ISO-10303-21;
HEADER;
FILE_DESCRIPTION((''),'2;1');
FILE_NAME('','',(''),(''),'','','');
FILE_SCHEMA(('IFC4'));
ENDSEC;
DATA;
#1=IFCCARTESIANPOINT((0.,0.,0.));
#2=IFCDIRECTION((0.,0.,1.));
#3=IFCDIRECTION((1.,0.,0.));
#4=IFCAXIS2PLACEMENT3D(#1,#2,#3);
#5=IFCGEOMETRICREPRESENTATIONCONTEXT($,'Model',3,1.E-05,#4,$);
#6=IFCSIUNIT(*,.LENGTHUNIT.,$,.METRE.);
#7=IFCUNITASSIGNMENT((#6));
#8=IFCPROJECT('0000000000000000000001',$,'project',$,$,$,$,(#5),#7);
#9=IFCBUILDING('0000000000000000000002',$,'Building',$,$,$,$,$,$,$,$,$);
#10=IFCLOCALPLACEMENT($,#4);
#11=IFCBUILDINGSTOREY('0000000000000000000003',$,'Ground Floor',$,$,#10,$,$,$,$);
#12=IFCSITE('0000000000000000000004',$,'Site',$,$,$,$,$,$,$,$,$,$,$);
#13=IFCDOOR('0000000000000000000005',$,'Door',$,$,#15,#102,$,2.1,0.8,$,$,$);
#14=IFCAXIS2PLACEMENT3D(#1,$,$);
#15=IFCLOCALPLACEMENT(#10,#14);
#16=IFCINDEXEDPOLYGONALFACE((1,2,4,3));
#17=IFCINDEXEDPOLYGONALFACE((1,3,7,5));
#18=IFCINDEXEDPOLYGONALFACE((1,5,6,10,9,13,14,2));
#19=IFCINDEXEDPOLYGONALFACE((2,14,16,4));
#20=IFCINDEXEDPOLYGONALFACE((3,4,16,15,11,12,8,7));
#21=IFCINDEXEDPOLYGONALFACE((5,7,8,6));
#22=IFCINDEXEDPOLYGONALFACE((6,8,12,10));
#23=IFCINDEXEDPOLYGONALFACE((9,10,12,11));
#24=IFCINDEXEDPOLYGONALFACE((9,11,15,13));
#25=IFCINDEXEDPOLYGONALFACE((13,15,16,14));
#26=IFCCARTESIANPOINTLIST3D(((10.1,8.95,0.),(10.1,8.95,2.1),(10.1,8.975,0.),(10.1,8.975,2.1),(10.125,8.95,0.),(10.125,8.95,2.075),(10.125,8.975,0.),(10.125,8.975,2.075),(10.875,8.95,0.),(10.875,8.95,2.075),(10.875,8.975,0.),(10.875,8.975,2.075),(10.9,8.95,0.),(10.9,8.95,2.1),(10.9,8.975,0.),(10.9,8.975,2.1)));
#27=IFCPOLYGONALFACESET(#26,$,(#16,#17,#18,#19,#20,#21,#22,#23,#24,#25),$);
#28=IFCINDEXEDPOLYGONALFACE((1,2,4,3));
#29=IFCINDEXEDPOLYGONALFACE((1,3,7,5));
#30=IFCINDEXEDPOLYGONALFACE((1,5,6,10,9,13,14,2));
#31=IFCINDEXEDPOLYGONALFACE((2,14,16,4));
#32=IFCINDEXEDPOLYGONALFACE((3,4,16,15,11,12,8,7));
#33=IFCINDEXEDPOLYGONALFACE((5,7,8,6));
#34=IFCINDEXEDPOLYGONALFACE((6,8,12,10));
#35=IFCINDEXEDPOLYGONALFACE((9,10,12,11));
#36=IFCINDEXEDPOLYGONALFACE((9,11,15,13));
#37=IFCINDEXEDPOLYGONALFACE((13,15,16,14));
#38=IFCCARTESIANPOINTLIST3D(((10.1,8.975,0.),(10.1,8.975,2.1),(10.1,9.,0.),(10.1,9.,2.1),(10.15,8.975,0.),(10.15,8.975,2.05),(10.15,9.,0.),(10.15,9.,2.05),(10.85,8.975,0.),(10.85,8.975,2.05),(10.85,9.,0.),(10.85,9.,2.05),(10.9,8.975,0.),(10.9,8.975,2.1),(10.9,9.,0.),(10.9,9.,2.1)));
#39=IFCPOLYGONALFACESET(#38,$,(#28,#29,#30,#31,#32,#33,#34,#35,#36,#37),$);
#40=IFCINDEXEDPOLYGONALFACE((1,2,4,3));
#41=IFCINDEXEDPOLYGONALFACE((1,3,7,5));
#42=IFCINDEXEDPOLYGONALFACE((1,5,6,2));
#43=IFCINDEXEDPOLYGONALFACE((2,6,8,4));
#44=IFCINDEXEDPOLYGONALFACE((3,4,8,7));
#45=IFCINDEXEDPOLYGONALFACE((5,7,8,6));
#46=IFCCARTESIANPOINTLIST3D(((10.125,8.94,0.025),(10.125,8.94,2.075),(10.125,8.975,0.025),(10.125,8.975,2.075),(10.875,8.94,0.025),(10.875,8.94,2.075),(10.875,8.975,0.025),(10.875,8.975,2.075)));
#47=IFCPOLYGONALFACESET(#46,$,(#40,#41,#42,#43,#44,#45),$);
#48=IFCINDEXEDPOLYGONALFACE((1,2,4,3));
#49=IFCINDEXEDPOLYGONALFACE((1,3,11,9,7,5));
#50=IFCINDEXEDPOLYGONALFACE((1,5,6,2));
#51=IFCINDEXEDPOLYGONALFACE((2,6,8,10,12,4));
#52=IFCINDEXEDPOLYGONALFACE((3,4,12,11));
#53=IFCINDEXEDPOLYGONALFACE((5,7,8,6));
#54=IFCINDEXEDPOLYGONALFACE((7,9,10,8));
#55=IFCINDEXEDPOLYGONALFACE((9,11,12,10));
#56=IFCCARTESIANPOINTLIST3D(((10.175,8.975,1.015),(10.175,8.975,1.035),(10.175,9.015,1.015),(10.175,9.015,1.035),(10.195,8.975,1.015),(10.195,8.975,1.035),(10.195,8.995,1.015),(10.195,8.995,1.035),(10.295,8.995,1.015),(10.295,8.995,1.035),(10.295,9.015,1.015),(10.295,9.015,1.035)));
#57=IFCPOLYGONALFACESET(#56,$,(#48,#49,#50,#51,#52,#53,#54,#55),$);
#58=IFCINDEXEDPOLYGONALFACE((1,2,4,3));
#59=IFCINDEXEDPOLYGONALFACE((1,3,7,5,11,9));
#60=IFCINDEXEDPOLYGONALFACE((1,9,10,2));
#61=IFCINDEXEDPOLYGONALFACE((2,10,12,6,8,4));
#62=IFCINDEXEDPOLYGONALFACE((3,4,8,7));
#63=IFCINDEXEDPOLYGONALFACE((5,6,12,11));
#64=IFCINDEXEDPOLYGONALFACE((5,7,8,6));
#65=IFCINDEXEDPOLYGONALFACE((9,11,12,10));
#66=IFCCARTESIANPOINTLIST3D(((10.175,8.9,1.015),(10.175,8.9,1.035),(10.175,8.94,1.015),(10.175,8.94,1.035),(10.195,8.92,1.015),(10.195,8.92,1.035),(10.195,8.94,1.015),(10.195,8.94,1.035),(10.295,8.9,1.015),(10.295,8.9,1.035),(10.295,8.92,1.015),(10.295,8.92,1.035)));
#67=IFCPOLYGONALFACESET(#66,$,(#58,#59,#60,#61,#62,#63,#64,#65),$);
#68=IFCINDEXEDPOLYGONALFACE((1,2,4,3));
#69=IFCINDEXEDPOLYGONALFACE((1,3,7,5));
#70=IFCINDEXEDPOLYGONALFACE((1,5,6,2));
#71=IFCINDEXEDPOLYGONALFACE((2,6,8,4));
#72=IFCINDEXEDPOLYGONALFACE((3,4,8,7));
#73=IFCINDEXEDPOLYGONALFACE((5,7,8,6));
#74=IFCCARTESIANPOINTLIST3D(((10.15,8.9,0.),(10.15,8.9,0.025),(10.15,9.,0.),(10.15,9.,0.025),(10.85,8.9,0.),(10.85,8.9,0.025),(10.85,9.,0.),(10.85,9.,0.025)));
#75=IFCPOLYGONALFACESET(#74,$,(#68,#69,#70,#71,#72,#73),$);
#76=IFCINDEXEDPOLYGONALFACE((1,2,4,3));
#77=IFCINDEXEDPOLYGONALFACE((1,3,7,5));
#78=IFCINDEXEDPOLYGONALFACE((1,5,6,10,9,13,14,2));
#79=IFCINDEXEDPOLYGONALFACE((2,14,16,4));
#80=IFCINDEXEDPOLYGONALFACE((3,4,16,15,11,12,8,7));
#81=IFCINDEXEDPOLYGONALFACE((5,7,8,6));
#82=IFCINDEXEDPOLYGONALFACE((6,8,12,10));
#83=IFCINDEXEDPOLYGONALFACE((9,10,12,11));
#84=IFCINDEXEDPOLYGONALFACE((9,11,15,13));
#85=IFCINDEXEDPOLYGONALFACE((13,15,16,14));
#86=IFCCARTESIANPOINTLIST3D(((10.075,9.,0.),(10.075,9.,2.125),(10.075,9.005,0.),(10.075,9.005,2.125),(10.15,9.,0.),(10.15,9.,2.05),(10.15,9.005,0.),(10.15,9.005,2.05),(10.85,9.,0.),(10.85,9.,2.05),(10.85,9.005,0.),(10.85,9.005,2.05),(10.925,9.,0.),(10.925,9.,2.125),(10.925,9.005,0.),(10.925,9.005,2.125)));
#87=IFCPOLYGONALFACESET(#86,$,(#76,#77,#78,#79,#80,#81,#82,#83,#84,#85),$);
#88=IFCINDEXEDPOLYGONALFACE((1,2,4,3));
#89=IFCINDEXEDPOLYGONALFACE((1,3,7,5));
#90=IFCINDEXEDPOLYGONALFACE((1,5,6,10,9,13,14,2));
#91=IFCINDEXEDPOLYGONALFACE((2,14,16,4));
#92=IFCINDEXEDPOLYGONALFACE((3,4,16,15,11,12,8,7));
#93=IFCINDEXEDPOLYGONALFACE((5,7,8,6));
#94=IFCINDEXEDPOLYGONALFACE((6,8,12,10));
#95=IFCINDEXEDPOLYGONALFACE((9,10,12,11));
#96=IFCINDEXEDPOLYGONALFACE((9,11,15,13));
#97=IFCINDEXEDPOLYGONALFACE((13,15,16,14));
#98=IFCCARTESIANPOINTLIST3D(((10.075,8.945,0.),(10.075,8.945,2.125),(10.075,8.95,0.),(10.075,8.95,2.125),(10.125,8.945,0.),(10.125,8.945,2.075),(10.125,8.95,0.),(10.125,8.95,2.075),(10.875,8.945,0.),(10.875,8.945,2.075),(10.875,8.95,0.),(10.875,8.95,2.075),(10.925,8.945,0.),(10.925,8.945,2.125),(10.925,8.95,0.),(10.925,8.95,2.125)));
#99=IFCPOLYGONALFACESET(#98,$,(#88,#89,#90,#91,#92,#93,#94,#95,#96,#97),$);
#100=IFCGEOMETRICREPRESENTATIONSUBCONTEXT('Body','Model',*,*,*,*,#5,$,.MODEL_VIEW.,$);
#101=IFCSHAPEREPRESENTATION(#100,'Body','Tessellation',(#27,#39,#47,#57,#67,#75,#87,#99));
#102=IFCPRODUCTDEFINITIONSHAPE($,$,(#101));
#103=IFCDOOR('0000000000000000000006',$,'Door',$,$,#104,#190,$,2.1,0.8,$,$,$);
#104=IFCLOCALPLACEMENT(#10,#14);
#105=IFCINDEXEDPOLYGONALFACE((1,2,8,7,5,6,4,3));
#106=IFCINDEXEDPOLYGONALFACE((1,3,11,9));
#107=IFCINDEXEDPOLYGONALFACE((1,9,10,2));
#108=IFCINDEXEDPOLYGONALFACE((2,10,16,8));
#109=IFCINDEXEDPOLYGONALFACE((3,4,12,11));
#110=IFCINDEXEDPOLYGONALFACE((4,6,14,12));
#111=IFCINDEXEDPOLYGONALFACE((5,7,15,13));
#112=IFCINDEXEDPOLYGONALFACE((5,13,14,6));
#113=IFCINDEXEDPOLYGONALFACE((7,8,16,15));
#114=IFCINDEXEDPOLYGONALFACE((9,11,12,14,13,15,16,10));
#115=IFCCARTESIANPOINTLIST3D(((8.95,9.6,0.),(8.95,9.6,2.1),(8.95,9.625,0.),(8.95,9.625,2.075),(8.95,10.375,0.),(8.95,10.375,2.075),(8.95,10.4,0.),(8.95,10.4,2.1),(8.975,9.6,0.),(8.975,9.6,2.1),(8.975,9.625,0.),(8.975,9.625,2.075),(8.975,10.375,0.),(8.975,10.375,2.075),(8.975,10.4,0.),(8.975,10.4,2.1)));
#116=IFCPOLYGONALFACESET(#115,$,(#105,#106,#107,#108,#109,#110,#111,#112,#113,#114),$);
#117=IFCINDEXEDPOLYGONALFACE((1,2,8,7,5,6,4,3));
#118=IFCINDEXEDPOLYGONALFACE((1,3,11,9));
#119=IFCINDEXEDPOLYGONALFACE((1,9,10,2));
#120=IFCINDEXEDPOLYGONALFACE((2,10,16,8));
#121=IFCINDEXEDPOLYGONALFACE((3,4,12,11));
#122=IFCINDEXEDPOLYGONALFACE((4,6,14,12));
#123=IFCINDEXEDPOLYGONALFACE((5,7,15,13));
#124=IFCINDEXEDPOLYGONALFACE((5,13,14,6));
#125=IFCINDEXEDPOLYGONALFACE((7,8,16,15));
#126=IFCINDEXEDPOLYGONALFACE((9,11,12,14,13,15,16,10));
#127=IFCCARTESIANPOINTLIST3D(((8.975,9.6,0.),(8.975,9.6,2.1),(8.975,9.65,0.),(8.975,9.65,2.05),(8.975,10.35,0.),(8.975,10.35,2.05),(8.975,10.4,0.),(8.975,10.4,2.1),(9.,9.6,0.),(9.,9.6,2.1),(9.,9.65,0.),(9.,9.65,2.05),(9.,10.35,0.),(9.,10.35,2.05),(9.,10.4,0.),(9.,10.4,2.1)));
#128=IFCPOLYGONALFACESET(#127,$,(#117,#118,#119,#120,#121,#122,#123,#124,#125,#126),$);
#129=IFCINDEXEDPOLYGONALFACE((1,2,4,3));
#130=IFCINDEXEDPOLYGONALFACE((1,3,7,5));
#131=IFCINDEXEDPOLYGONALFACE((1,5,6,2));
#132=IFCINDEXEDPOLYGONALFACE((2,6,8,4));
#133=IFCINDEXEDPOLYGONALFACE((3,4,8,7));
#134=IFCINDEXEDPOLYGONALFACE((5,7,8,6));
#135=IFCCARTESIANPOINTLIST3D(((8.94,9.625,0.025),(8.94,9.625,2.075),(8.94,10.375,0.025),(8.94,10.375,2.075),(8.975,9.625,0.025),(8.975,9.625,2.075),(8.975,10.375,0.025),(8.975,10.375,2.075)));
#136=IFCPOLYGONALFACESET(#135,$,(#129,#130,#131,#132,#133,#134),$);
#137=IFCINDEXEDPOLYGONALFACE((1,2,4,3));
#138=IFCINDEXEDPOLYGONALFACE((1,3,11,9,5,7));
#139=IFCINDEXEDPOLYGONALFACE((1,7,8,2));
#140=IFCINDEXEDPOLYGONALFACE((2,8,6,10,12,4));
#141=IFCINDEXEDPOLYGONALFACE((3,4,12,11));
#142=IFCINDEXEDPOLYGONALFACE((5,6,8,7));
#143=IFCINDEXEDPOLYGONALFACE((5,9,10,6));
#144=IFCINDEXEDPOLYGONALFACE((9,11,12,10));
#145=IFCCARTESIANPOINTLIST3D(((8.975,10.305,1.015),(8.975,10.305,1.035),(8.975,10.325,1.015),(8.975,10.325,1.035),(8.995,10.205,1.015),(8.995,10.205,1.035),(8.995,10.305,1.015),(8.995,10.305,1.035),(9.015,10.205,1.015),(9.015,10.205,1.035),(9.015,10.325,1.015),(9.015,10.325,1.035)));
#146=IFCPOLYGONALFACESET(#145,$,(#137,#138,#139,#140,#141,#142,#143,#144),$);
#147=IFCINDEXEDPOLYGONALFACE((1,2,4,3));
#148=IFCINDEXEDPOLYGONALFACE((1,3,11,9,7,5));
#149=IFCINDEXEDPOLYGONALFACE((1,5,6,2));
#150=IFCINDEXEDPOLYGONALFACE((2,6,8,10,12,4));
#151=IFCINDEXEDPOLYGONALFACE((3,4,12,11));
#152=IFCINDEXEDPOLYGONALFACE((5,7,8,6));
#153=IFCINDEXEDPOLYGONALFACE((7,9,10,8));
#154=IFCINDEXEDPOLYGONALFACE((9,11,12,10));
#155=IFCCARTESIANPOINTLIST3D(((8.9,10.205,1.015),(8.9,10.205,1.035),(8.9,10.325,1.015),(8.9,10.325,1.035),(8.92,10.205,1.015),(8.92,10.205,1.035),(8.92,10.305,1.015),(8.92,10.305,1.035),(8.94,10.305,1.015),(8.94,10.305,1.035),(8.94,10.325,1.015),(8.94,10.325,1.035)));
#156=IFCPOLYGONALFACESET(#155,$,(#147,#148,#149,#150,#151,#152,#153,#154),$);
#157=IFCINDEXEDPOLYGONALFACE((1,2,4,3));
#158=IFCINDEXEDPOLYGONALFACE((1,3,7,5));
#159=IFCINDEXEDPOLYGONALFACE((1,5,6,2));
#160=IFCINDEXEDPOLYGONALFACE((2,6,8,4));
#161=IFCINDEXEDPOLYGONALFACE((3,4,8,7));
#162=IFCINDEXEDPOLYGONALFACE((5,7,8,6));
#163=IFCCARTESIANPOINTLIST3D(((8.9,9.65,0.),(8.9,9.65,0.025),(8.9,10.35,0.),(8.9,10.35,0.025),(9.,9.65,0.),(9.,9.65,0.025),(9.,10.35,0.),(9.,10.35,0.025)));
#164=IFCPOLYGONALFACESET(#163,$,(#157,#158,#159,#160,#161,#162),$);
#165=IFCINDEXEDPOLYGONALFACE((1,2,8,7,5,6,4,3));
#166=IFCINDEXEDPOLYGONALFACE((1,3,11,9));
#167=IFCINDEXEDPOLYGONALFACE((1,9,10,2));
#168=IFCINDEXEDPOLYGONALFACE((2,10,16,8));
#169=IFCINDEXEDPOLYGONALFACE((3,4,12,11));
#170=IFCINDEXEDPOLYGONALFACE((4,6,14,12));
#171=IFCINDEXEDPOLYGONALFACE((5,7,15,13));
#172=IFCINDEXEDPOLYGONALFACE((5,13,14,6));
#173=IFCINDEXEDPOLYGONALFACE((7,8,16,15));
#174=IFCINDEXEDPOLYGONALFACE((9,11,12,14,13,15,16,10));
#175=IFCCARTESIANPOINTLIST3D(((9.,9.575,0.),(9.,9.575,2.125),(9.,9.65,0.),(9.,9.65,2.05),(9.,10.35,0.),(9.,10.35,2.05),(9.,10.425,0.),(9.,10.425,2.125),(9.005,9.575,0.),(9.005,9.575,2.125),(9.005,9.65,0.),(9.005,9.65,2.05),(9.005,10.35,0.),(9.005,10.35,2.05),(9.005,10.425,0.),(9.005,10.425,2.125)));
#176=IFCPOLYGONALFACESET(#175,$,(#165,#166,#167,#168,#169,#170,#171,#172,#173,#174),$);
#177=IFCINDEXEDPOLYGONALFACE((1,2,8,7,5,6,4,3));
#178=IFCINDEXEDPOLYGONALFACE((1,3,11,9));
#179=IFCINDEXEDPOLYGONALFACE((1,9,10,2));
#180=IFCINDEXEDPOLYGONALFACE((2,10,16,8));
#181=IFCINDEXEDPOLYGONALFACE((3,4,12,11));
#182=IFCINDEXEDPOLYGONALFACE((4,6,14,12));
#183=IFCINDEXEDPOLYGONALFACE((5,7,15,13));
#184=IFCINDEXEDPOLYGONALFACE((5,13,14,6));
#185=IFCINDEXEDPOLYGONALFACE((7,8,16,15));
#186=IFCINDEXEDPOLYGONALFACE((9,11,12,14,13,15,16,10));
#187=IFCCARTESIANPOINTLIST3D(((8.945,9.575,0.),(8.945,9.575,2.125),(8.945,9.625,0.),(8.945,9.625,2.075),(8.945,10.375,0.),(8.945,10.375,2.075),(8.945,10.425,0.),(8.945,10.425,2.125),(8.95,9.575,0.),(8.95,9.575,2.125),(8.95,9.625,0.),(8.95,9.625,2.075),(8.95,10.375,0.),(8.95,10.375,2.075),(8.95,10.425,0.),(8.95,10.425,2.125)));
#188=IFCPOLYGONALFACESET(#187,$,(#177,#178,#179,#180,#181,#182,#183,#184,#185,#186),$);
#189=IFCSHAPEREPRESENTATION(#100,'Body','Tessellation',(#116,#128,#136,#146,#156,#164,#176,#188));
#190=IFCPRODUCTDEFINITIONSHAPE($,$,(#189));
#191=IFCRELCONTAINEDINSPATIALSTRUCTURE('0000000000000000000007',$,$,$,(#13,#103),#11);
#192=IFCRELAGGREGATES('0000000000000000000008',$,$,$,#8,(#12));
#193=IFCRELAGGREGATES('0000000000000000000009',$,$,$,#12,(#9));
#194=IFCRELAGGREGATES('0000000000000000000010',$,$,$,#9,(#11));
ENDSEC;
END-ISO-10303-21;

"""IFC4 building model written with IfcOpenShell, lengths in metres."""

from ifc_helpers import new_model, si_unit, frame, origin_with_axes, place, context, subcontext, project, spatial, line, indexed_curve, outline, extrude, element, save


model = new_model("IFC4")

# Units and contexts
model_context = context("Model", 3, precision=1e-05, world=origin_with_axes())
body_context = subcontext(model_context, "Body", "Model", "MODEL_VIEW")
ifc_project = project(units=[si_unit("LENGTHUNIT", "METRE")], contexts=[model_context])

# Site, building, storey
site = spatial("IfcSite", under=ifc_project, Name="Site")
building = spatial("IfcBuilding", under=site, Name="Building")
storey_placement = place(None, origin_with_axes())
storey = spatial("IfcBuildingStorey", under=building, at=storey_placement, Name="Ground Floor")

# Doors
door_1_placement = place(storey_placement, frame((10.9, 9.0, 0.0), z_axis=(0.0, 0.0, 1.0), x_axis=(-1.0, 0.0, 0.0)))
element("IfcDoor", 1, at=door_1_placement, inside=storey, Name="Door", OverallHeight=2.1, OverallWidth=0.8, context=body_context, shape_type="SweptSolid", body=[
    extrude(outline(indexed_curve([(0.0, 0.0), (0.0, 2.1), (0.8, 2.1), (0.8, 0.0), (0.775, 0.0), (0.775, 2.075), (0.025, 2.075), (0.025, 0.0)], segments=[line(1, 2, 3, 4, 5, 6, 7, 8, 1)])), frame((0.0, 0.025, 0.0), z_axis=(0.0, -1.0, 0.0), x_axis=(1.0, 0.0, 0.0)), (0.0, 0.0, -1.0), 0.025),
    extrude(outline(indexed_curve([(0.0, 0.0), (0.0, 2.1), (0.8, 2.1), (0.8, 0.0), (0.75, 0.0), (0.75, 2.05), (0.05, 2.05), (0.05, 0.0)], segments=[line(1, 2, 3, 4, 5, 6, 7, 8, 1)])), frame((0.0, 0.0, 0.0), z_axis=(0.0, -1.0, 0.0), x_axis=(1.0, 0.0, 0.0)), (0.0, 0.0, -1.0), 0.025),
    extrude(outline(indexed_curve([(0.0, 0.0), (0.75, 0.0), (0.75, 0.035), (0.0, 0.035)], segments=[line(1, 2, 3, 4, 1)])), frame((0.025, 0.025, 0.025), z_axis=(0.0, 0.0, 1.0), x_axis=(1.0, 0.0, 0.0)), (0.0, 0.0, 1.0), 2.05),
    extrude(outline(indexed_curve([(0.0, 0.0), (0.0, -0.04), (-0.12, -0.04), (-0.12, -0.02), (-0.02, -0.02), (-0.02, 0.0)], segments=[line(1, 2, 3, 4, 5, 6, 1)])), frame((0.725, 0.025, 1.015), z_axis=(0.0, 0.0, 1.0), x_axis=(1.0, 0.0, 0.0)), (0.0, 0.0, 1.0), 0.02),
    extrude(outline(indexed_curve([(0.0, 0.0), (0.0, 0.04), (-0.12, 0.04), (-0.12, 0.02), (-0.02, 0.02), (-0.02, 0.0)], segments=[line(1, 2, 3, 4, 5, 6, 1)])), frame((0.725, 0.06, 1.015), z_axis=(0.0, 0.0, 1.0), x_axis=(1.0, 0.0, 0.0)), (0.0, 0.0, 1.0), 0.02),
    extrude(outline(indexed_curve([(0.0, 0.0), (0.7, 0.0), (0.7, 0.1), (0.0, 0.1)], segments=[line(1, 2, 3, 4, 1)])), frame((0.05, 0.0, 0.0), z_axis=(0.0, 0.0, 1.0), x_axis=(1.0, 0.0, 0.0)), (0.0, 0.0, 1.0), 0.025),
    extrude(outline(indexed_curve([(0.0, 0.0), (0.0, 2.125), (0.85, 2.125), (0.85, 0.0), (0.775, 0.0), (0.775, 2.05), (0.075, 2.05), (0.075, 0.0)], segments=[line(1, 2, 3, 4, 5, 6, 7, 8, 1)])), frame((-0.025, -0.005, 0.0), z_axis=(0.0, -1.0, 0.0), x_axis=(1.0, 0.0, 0.0)), (0.0, 0.0, -1.0), 0.005),
    extrude(outline(indexed_curve([(0.0, 0.0), (0.0, 2.125), (0.85, 2.125), (0.85, 0.0), (0.8, 0.0), (0.8, 2.075), (0.05, 2.075), (0.05, 0.0)], segments=[line(1, 2, 3, 4, 5, 6, 7, 8, 1)])), frame((-0.025, 0.05, 0.0), z_axis=(0.0, -1.0, 0.0), x_axis=(1.0, 0.0, 0.0)), (0.0, 0.0, -1.0), 0.005),
])
door_2_placement = place(storey_placement, frame((9.0, 9.6, 0.0), z_axis=(0.0, 0.0, 1.0), x_axis=(0.0, 1.0, 0.0)))
element("IfcDoor", 2, at=door_2_placement, inside=storey, Name="Door", OverallHeight=2.1, OverallWidth=0.8, context=body_context, shape_type="SweptSolid", body=[
    extrude(outline(indexed_curve([(0.0, 0.0), (0.0, 2.1), (0.8, 2.1), (0.8, 0.0), (0.775, 0.0), (0.775, 2.075), (0.025, 2.075), (0.025, 0.0)], segments=[line(1, 2, 3, 4, 5, 6, 7, 8, 1)])), frame((0.0, 0.025, 0.0), z_axis=(0.0, -1.0, 0.0), x_axis=(1.0, 0.0, 0.0)), (0.0, 0.0, -1.0), 0.025),
    extrude(outline(indexed_curve([(0.0, 0.0), (0.0, 2.1), (0.8, 2.1), (0.8, 0.0), (0.75, 0.0), (0.75, 2.05), (0.05, 2.05), (0.05, 0.0)], segments=[line(1, 2, 3, 4, 5, 6, 7, 8, 1)])), frame((0.0, 0.0, 0.0), z_axis=(0.0, -1.0, 0.0), x_axis=(1.0, 0.0, 0.0)), (0.0, 0.0, -1.0), 0.025),
    extrude(outline(indexed_curve([(0.0, 0.0), (0.75, 0.0), (0.75, 0.035), (0.0, 0.035)], segments=[line(1, 2, 3, 4, 1)])), frame((0.025, 0.025, 0.025), z_axis=(0.0, 0.0, 1.0), x_axis=(1.0, 0.0, 0.0)), (0.0, 0.0, 1.0), 2.05),
    extrude(outline(indexed_curve([(0.0, 0.0), (0.0, -0.04), (-0.12, -0.04), (-0.12, -0.02), (-0.02, -0.02), (-0.02, 0.0)], segments=[line(1, 2, 3, 4, 5, 6, 1)])), frame((0.725, 0.025, 1.015), z_axis=(0.0, 0.0, 1.0), x_axis=(1.0, 0.0, 0.0)), (0.0, 0.0, 1.0), 0.02),
    extrude(outline(indexed_curve([(0.0, 0.0), (0.0, 0.04), (-0.12, 0.04), (-0.12, 0.02), (-0.02, 0.02), (-0.02, 0.0)], segments=[line(1, 2, 3, 4, 5, 6, 1)])), frame((0.725, 0.06, 1.015), z_axis=(0.0, 0.0, 1.0), x_axis=(1.0, 0.0, 0.0)), (0.0, 0.0, 1.0), 0.02),
    extrude(outline(indexed_curve([(0.0, 0.0), (0.7, 0.0), (0.7, 0.1), (0.0, 0.1)], segments=[line(1, 2, 3, 4, 1)])), frame((0.05, 0.0, 0.0), z_axis=(0.0, 0.0, 1.0), x_axis=(1.0, 0.0, 0.0)), (0.0, 0.0, 1.0), 0.025),
    extrude(outline(indexed_curve([(0.0, 0.0), (0.0, 2.125), (0.85, 2.125), (0.85, 0.0), (0.775, 0.0), (0.775, 2.05), (0.075, 2.05), (0.075, 0.0)], segments=[line(1, 2, 3, 4, 5, 6, 7, 8, 1)])), frame((-0.025, -0.005, 0.0), z_axis=(0.0, -1.0, 0.0), x_axis=(1.0, 0.0, 0.0)), (0.0, 0.0, -1.0), 0.005),
    extrude(outline(indexed_curve([(0.0, 0.0), (0.0, 2.125), (0.85, 2.125), (0.85, 0.0), (0.8, 0.0), (0.8, 2.075), (0.05, 2.075), (0.05, 0.0)], segments=[line(1, 2, 3, 4, 5, 6, 7, 8, 1)])), frame((-0.025, 0.05, 0.0), z_axis=(0.0, -1.0, 0.0), x_axis=(1.0, 0.0, 0.0)), (0.0, 0.0, -1.0), 0.005),
])

save(model, "model.ifc")
